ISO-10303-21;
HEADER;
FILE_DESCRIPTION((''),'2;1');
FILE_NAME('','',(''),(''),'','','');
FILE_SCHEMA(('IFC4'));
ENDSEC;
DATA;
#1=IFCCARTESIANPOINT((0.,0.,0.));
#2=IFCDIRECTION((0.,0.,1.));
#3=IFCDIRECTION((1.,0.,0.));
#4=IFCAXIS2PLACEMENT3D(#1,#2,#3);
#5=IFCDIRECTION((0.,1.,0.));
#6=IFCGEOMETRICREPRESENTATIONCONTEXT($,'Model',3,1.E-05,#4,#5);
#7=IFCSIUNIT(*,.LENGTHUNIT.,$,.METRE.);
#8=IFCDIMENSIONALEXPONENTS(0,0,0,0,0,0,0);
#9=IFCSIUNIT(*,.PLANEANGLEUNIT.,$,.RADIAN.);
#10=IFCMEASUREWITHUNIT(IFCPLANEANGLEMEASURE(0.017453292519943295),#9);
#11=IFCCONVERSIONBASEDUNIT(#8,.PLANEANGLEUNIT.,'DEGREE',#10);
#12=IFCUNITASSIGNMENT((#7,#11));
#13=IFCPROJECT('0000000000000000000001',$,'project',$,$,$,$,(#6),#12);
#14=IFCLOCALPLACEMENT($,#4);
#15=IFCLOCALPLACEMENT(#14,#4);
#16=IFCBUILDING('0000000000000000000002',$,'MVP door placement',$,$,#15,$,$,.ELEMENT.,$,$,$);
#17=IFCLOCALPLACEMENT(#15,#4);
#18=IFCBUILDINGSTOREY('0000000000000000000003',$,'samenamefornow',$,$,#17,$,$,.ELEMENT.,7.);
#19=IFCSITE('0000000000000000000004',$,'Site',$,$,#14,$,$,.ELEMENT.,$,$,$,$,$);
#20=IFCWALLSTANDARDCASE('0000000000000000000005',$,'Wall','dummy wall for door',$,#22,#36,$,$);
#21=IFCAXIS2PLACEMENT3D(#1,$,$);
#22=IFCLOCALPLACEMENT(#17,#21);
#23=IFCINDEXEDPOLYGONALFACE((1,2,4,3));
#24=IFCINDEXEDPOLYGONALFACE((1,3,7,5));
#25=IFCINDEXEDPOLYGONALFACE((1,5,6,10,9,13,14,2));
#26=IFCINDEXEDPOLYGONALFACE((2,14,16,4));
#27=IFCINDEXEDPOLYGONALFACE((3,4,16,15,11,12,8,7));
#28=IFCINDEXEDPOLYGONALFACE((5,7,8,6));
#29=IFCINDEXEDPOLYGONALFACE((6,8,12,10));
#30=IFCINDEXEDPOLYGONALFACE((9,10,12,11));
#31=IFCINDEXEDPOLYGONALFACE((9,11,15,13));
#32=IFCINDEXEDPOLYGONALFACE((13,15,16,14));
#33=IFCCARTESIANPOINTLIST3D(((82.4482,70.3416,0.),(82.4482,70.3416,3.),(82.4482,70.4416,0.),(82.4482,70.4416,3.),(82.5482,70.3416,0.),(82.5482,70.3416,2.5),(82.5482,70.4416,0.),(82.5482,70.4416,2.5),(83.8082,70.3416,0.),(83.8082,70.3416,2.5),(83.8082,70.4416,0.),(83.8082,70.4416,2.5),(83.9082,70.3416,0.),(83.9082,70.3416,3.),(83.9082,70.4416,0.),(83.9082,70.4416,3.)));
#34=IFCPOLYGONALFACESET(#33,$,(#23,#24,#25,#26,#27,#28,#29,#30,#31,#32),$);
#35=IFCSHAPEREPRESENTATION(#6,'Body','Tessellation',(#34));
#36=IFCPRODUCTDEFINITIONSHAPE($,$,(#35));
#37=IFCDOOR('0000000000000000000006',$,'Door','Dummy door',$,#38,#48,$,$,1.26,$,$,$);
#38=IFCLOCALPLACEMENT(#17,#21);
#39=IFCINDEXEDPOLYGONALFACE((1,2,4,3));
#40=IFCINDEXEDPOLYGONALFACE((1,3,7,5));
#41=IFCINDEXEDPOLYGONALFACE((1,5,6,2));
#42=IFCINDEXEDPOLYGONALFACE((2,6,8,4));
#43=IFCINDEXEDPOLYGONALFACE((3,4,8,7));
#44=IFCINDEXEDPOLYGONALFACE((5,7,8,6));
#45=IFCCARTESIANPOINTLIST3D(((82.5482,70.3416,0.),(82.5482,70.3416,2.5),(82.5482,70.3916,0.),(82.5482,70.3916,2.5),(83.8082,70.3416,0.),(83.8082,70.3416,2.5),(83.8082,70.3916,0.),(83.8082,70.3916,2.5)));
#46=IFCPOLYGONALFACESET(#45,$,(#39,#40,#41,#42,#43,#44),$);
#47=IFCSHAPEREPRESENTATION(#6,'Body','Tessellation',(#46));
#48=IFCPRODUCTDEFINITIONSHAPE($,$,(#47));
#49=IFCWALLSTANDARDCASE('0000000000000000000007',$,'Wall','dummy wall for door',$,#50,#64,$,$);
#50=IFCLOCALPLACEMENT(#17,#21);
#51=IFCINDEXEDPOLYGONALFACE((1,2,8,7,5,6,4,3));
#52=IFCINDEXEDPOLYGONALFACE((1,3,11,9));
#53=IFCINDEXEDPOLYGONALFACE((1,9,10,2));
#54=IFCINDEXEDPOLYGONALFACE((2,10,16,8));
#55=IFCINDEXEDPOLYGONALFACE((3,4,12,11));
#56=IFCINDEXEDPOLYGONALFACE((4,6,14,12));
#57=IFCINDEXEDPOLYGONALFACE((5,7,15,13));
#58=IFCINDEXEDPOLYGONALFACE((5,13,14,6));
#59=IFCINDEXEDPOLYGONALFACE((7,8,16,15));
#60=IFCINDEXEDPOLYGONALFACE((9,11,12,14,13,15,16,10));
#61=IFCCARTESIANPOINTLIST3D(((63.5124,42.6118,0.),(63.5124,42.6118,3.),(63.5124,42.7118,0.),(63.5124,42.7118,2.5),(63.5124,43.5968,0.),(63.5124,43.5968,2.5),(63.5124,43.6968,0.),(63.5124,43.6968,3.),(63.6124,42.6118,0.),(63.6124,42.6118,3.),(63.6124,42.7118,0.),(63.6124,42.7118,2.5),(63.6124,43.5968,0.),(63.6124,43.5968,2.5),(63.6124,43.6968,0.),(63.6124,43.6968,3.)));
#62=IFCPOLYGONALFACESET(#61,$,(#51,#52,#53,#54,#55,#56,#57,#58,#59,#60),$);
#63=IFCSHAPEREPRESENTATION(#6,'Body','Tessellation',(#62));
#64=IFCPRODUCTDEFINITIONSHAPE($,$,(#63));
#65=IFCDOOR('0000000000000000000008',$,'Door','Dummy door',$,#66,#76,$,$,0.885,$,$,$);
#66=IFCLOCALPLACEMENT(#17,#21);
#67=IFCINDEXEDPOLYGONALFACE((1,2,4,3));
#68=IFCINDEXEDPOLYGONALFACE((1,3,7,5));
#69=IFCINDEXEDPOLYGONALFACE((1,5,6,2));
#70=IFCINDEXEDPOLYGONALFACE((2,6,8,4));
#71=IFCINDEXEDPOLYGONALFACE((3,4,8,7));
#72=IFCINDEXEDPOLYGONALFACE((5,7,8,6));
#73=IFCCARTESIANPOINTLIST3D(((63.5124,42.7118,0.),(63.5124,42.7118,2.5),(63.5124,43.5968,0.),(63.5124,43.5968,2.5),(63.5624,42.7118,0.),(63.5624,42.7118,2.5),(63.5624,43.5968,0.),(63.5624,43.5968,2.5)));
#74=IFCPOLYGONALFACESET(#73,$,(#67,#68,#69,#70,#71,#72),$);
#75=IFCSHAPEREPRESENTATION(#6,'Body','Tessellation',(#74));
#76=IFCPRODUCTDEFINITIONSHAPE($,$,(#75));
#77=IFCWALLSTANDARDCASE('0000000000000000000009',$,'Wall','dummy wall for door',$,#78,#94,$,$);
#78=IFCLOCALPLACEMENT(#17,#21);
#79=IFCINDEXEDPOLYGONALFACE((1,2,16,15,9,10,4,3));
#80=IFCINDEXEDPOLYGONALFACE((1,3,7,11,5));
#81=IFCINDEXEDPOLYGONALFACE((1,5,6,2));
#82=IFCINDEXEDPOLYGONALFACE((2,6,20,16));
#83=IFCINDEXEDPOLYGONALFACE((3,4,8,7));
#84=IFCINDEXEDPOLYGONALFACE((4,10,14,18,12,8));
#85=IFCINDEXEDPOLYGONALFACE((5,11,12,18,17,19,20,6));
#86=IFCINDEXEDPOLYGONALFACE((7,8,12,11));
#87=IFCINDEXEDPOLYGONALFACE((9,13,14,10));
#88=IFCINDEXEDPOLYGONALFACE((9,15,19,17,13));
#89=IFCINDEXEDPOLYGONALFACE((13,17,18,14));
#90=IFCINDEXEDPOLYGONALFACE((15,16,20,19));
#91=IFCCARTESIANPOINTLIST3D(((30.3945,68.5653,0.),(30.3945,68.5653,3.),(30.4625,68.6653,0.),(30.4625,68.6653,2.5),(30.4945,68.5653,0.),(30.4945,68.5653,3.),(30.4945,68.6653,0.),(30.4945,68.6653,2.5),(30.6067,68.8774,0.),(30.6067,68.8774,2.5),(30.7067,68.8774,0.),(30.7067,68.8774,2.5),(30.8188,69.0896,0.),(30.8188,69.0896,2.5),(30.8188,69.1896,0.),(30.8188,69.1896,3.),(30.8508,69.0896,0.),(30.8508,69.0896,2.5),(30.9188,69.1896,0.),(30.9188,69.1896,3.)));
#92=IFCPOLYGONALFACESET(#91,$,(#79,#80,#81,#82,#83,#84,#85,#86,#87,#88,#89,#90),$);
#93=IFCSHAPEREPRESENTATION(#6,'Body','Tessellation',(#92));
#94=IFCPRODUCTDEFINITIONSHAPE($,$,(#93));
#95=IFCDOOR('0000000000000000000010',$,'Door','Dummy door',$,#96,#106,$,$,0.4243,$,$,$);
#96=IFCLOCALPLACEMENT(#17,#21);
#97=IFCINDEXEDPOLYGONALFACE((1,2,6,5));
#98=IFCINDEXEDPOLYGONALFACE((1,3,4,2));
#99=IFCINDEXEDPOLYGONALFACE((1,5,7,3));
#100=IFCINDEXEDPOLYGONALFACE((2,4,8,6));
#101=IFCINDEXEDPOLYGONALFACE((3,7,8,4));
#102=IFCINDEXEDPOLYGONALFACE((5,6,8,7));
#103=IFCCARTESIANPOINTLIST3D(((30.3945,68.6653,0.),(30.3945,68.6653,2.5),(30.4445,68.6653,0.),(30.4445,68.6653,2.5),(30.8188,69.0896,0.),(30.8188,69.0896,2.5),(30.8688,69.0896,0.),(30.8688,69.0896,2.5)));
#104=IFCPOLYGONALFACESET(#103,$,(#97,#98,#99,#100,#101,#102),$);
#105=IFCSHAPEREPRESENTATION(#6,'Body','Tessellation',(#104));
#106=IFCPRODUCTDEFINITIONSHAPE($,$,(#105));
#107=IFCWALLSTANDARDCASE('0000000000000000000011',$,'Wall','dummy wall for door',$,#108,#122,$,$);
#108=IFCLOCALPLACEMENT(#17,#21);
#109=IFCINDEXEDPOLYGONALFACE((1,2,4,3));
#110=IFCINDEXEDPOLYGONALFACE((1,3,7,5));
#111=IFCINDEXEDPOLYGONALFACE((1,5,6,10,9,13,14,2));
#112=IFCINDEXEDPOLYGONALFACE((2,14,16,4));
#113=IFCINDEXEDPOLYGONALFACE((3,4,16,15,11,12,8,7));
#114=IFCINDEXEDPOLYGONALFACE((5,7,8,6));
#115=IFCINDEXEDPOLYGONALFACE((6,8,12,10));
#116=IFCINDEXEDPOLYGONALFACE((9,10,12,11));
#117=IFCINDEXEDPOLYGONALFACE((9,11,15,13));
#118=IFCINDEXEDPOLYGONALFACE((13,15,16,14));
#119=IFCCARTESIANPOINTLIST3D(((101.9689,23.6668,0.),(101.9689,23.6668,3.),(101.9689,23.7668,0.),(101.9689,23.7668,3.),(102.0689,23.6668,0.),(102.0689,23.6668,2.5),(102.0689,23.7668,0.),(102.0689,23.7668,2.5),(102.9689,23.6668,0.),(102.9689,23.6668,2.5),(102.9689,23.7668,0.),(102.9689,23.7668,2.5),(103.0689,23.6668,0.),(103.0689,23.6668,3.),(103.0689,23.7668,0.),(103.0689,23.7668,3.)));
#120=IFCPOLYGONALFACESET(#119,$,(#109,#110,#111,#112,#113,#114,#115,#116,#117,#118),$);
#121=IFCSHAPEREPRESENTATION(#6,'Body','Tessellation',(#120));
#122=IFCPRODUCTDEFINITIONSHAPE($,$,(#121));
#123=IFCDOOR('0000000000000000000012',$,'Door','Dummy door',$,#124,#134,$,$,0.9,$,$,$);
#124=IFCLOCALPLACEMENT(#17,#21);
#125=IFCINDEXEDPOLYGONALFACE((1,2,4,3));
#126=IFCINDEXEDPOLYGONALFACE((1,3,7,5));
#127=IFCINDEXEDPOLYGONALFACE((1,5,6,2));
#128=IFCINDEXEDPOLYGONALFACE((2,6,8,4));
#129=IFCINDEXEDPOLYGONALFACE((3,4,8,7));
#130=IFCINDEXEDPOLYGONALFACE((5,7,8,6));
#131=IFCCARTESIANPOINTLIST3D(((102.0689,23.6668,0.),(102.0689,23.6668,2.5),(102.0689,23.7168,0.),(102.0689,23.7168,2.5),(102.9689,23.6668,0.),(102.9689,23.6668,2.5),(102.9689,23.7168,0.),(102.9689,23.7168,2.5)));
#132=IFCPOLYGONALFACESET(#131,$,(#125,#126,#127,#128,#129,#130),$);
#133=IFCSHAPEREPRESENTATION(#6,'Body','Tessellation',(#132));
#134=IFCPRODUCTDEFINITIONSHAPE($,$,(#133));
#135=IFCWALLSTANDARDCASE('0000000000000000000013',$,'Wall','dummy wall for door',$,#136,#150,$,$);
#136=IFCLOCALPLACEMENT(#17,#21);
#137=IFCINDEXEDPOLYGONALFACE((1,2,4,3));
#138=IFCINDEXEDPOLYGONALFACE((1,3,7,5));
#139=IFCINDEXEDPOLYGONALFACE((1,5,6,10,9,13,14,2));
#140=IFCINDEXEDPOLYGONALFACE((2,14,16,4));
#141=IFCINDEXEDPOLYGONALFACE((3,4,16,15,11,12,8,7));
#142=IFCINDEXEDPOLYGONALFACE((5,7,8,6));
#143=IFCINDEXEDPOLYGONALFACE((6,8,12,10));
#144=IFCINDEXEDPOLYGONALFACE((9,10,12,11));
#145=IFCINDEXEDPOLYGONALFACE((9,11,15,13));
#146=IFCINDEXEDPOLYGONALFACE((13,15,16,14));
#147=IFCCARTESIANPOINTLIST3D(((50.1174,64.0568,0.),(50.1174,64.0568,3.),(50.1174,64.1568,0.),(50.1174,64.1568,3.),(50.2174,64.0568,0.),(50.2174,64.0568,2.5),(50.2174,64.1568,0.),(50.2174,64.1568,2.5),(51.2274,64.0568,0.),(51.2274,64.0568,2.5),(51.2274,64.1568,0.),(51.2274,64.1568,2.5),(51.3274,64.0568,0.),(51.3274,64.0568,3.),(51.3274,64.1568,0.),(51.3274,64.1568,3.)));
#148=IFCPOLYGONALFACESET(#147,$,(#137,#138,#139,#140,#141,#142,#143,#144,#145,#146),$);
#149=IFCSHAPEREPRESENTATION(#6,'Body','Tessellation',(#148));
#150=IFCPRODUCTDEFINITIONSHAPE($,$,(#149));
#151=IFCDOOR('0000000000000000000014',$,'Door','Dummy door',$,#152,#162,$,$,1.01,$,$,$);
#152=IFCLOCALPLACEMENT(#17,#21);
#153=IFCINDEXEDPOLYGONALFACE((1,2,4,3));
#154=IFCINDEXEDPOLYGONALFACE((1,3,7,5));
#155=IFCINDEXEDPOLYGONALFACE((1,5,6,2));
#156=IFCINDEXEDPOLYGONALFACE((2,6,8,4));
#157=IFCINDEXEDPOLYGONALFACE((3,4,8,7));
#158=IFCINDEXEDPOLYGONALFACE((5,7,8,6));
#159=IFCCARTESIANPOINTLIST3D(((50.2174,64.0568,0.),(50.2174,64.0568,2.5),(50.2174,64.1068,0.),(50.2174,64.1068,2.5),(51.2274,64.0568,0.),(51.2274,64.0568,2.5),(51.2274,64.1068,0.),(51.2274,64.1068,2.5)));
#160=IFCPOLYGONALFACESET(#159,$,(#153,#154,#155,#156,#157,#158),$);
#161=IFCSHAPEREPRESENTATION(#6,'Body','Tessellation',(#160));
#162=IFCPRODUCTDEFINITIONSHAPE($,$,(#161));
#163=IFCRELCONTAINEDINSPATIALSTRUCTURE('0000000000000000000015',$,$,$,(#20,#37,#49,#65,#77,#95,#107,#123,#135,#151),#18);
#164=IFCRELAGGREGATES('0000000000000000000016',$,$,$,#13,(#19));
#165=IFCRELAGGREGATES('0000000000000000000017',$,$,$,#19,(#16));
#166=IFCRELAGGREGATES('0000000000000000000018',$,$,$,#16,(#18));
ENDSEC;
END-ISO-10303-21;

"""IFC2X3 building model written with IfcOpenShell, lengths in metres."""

from ifc_helpers import new_model, entity, si_unit, converted_unit, direction, origin_with_axes, place, context, project, spatial, polyline, outline, extrude, element, fill, save


model = new_model("IFC2X3")

# Units and contexts
model_context = context("Model", 3, precision=1e-05, world=origin_with_axes(), true_north=direction((0.0, 1.0, 0.0)))
ifc_project = project(units=[si_unit("LENGTHUNIT", "METRE"), converted_unit("PLANEANGLEUNIT", "DEGREE", entity("IfcPlaneAngleMeasure", 0.017453292519943295), si_unit("PLANEANGLEUNIT", "RADIAN"), dimensions=[0, 0, 0, 0, 0, 0, 0])], contexts=[model_context])

# Site, building, storey
site_placement = place(None, origin_with_axes())
site = spatial("IfcSite", under=ifc_project, at=site_placement, Name="Site", CompositionType="ELEMENT")
building_placement = place(site_placement, origin_with_axes())
building = spatial("IfcBuilding", under=site, at=building_placement, Name="MVP door placement", CompositionType="ELEMENT")
storey_placement = place(building_placement, origin_with_axes())
storey = spatial("IfcBuildingStorey", under=building, at=storey_placement, Name="samenamefornow", CompositionType="ELEMENT", Elevation=7.0)

# Walls, openings, doors
wall_1_placement = place(storey_placement, origin_with_axes())
wall_1 = element("IfcWallStandardCase", 1, at=wall_1_placement, inside=storey, Name="Wall", Description="dummy wall for door", context=model_context, shape_type="SweptSolid", body=[
    extrude(outline(polyline([(82.4482, 70.3416, 0.0), (83.9082, 70.3416, 0.0), (83.9082, 70.4416, 0.0), (82.4482, 70.4416, 0.0), (82.4482, 70.3416, 0.0)])), origin_with_axes(), (0.0, 0.0, 1.0), 3.0),
])
opening_1_placement = place(wall_1_placement, origin_with_axes())
opening_1 = element("IfcOpeningElement", 2, at=opening_1_placement, cuts=wall_1, context=model_context, shape_type="SweptSolid", body=[
    extrude(outline(polyline([(82.5482, 70.3416, 0.0), (83.8082, 70.3416, 0.0), (83.8082, 70.4416, 0.0), (82.5482, 70.4416, 0.0), (82.5482, 70.3416, 0.0)])), origin_with_axes(), (0.0, 0.0, 1.0), 2.5),
])
door_1_placement = place(opening_1_placement, origin_with_axes())
door_1 = element("IfcDoor", 3, at=door_1_placement, inside=storey, Name="Door", Description="Dummy door", OverallWidth=1.26, context=model_context, shape_type="SweptSolid", body=[
    extrude(outline(polyline([(82.5482, 70.3416, 0.0), (83.8082, 70.3416, 0.0), (83.8082, 70.3916, 0.0), (82.5482, 70.3916, 0.0), (82.5482, 70.3416, 0.0)])), origin_with_axes(), (0.0, 0.0, 1.0), 2.5),
])
fill(opening_1, door_1)
wall_2_placement = place(storey_placement, origin_with_axes())
wall_2 = element("IfcWallStandardCase", 4, at=wall_2_placement, inside=storey, Name="Wall", Description="dummy wall for door", context=model_context, shape_type="SweptSolid", body=[
    extrude(outline(polyline([(63.5124, 42.6118, 0.0), (63.5124, 43.6968, 0.0), (63.6124, 43.6968, 0.0), (63.6124, 42.6118, 0.0), (63.5124, 42.6118, 0.0)])), origin_with_axes(), (0.0, 0.0, 1.0), 3.0),
])
opening_2_placement = place(wall_2_placement, origin_with_axes())
opening_2 = element("IfcOpeningElement", 5, at=opening_2_placement, cuts=wall_2, context=model_context, shape_type="SweptSolid", body=[
    extrude(outline(polyline([(63.5124, 42.7118, 0.0), (63.5124, 43.5968, 0.0), (63.6124, 43.5968, 0.0), (63.6124, 42.7118, 0.0), (63.5124, 42.7118, 0.0)])), origin_with_axes(), (0.0, 0.0, 1.0), 2.5),
])
door_2_placement = place(opening_2_placement, origin_with_axes())
door_2 = element("IfcDoor", 6, at=door_2_placement, inside=storey, Name="Door", Description="Dummy door", OverallWidth=0.885, context=model_context, shape_type="SweptSolid", body=[
    extrude(outline(polyline([(63.5124, 42.7118, 0.0), (63.5124, 43.5968, 0.0), (63.5624, 43.5968, 0.0), (63.5624, 42.7118, 0.0), (63.5124, 42.7118, 0.0)])), origin_with_axes(), (0.0, 0.0, 1.0), 2.5),
])
fill(opening_2, door_2)
wall_3_placement = place(storey_placement, origin_with_axes())
wall_3 = element("IfcWallStandardCase", 7, at=wall_3_placement, inside=storey, Name="Wall", Description="dummy wall for door", context=model_context, shape_type="SweptSolid", body=[
    extrude(outline(polyline([(30.8188, 69.1896, 0.0), (30.3945, 68.5653, 0.0), (30.4945, 68.5653, 0.0), (30.9188, 69.1896, 0.0), (30.8188, 69.1896, 0.0)])), origin_with_axes(), (0.0, 0.0, 1.0), 3.0),
])
opening_3_placement = place(wall_3_placement, origin_with_axes())
opening_3 = element("IfcOpeningElement", 8, at=opening_3_placement, cuts=wall_3, context=model_context, shape_type="SweptSolid", body=[
    extrude(outline(polyline([(30.8188, 69.0896, 0.0), (30.3945, 68.6653, 0.0), (30.4945, 68.6653, 0.0), (30.9188, 69.0896, 0.0), (30.8188, 69.0896, 0.0)])), origin_with_axes(), (0.0, 0.0, 1.0), 2.5),
])
door_3_placement = place(opening_3_placement, origin_with_axes())
door_3 = element("IfcDoor", 9, at=door_3_placement, inside=storey, Name="Door", Description="Dummy door", OverallWidth=0.4243, context=model_context, shape_type="SweptSolid", body=[
    extrude(outline(polyline([(30.8188, 69.0896, 0.0), (30.3945, 68.6653, 0.0), (30.4445, 68.6653, 0.0), (30.8688, 69.0896, 0.0), (30.8188, 69.0896, 0.0)])), origin_with_axes(), (0.0, 0.0, 1.0), 2.5),
])
fill(opening_3, door_3)
wall_4_placement = place(storey_placement, origin_with_axes())
wall_4 = element("IfcWallStandardCase", 10, at=wall_4_placement, inside=storey, Name="Wall", Description="dummy wall for door", context=model_context, shape_type="SweptSolid", body=[
    extrude(outline(polyline([(103.0689, 23.6668, 0.0), (101.9689, 23.6668, 0.0), (101.9689, 23.7668, 0.0), (103.0689, 23.7668, 0.0), (103.0689, 23.6668, 0.0)])), origin_with_axes(), (0.0, 0.0, 1.0), 3.0),
])
opening_4_placement = place(wall_4_placement, origin_with_axes())
opening_4 = element("IfcOpeningElement", 11, at=opening_4_placement, cuts=wall_4, context=model_context, shape_type="SweptSolid", body=[
    extrude(outline(polyline([(102.9689, 23.6668, 0.0), (102.0689, 23.6668, 0.0), (102.0689, 23.7668, 0.0), (102.9689, 23.7668, 0.0), (102.9689, 23.6668, 0.0)])), origin_with_axes(), (0.0, 0.0, 1.0), 2.5),
])
door_4_placement = place(opening_4_placement, origin_with_axes())
door_4 = element("IfcDoor", 12, at=door_4_placement, inside=storey, Name="Door", Description="Dummy door", OverallWidth=0.9, context=model_context, shape_type="SweptSolid", body=[
    extrude(outline(polyline([(102.9689, 23.6668, 0.0), (102.0689, 23.6668, 0.0), (102.0689, 23.7168, 0.0), (102.9689, 23.7168, 0.0), (102.9689, 23.6668, 0.0)])), origin_with_axes(), (0.0, 0.0, 1.0), 2.5),
])
fill(opening_4, door_4)
wall_5_placement = place(storey_placement, origin_with_axes())
wall_5 = element("IfcWallStandardCase", 13, at=wall_5_placement, inside=storey, Name="Wall", Description="dummy wall for door", context=model_context, shape_type="SweptSolid", body=[
    extrude(outline(polyline([(51.3274, 64.0568, 0.0), (50.1174, 64.0568, 0.0), (50.1174, 64.1568, 0.0), (51.3274, 64.1568, 0.0), (51.3274, 64.0568, 0.0)])), origin_with_axes(), (0.0, 0.0, 1.0), 3.0),
])
opening_5_placement = place(wall_5_placement, origin_with_axes())
opening_5 = element("IfcOpeningElement", 14, at=opening_5_placement, cuts=wall_5, context=model_context, shape_type="SweptSolid", body=[
    extrude(outline(polyline([(51.2274, 64.0568, 0.0), (50.2174, 64.0568, 0.0), (50.2174, 64.1568, 0.0), (51.2274, 64.1568, 0.0), (51.2274, 64.0568, 0.0)])), origin_with_axes(), (0.0, 0.0, 1.0), 2.5),
])
door_5_placement = place(opening_5_placement, origin_with_axes())
door_5 = element("IfcDoor", 15, at=door_5_placement, inside=storey, Name="Door", Description="Dummy door", OverallWidth=1.01, context=model_context, shape_type="SweptSolid", body=[
    extrude(outline(polyline([(51.2274, 64.0568, 0.0), (50.2174, 64.0568, 0.0), (50.2174, 64.1068, 0.0), (51.2274, 64.1068, 0.0), (51.2274, 64.0568, 0.0)])), origin_with_axes(), (0.0, 0.0, 1.0), 2.5),
])
fill(opening_5, door_5)

save(model, "model.ifc")
